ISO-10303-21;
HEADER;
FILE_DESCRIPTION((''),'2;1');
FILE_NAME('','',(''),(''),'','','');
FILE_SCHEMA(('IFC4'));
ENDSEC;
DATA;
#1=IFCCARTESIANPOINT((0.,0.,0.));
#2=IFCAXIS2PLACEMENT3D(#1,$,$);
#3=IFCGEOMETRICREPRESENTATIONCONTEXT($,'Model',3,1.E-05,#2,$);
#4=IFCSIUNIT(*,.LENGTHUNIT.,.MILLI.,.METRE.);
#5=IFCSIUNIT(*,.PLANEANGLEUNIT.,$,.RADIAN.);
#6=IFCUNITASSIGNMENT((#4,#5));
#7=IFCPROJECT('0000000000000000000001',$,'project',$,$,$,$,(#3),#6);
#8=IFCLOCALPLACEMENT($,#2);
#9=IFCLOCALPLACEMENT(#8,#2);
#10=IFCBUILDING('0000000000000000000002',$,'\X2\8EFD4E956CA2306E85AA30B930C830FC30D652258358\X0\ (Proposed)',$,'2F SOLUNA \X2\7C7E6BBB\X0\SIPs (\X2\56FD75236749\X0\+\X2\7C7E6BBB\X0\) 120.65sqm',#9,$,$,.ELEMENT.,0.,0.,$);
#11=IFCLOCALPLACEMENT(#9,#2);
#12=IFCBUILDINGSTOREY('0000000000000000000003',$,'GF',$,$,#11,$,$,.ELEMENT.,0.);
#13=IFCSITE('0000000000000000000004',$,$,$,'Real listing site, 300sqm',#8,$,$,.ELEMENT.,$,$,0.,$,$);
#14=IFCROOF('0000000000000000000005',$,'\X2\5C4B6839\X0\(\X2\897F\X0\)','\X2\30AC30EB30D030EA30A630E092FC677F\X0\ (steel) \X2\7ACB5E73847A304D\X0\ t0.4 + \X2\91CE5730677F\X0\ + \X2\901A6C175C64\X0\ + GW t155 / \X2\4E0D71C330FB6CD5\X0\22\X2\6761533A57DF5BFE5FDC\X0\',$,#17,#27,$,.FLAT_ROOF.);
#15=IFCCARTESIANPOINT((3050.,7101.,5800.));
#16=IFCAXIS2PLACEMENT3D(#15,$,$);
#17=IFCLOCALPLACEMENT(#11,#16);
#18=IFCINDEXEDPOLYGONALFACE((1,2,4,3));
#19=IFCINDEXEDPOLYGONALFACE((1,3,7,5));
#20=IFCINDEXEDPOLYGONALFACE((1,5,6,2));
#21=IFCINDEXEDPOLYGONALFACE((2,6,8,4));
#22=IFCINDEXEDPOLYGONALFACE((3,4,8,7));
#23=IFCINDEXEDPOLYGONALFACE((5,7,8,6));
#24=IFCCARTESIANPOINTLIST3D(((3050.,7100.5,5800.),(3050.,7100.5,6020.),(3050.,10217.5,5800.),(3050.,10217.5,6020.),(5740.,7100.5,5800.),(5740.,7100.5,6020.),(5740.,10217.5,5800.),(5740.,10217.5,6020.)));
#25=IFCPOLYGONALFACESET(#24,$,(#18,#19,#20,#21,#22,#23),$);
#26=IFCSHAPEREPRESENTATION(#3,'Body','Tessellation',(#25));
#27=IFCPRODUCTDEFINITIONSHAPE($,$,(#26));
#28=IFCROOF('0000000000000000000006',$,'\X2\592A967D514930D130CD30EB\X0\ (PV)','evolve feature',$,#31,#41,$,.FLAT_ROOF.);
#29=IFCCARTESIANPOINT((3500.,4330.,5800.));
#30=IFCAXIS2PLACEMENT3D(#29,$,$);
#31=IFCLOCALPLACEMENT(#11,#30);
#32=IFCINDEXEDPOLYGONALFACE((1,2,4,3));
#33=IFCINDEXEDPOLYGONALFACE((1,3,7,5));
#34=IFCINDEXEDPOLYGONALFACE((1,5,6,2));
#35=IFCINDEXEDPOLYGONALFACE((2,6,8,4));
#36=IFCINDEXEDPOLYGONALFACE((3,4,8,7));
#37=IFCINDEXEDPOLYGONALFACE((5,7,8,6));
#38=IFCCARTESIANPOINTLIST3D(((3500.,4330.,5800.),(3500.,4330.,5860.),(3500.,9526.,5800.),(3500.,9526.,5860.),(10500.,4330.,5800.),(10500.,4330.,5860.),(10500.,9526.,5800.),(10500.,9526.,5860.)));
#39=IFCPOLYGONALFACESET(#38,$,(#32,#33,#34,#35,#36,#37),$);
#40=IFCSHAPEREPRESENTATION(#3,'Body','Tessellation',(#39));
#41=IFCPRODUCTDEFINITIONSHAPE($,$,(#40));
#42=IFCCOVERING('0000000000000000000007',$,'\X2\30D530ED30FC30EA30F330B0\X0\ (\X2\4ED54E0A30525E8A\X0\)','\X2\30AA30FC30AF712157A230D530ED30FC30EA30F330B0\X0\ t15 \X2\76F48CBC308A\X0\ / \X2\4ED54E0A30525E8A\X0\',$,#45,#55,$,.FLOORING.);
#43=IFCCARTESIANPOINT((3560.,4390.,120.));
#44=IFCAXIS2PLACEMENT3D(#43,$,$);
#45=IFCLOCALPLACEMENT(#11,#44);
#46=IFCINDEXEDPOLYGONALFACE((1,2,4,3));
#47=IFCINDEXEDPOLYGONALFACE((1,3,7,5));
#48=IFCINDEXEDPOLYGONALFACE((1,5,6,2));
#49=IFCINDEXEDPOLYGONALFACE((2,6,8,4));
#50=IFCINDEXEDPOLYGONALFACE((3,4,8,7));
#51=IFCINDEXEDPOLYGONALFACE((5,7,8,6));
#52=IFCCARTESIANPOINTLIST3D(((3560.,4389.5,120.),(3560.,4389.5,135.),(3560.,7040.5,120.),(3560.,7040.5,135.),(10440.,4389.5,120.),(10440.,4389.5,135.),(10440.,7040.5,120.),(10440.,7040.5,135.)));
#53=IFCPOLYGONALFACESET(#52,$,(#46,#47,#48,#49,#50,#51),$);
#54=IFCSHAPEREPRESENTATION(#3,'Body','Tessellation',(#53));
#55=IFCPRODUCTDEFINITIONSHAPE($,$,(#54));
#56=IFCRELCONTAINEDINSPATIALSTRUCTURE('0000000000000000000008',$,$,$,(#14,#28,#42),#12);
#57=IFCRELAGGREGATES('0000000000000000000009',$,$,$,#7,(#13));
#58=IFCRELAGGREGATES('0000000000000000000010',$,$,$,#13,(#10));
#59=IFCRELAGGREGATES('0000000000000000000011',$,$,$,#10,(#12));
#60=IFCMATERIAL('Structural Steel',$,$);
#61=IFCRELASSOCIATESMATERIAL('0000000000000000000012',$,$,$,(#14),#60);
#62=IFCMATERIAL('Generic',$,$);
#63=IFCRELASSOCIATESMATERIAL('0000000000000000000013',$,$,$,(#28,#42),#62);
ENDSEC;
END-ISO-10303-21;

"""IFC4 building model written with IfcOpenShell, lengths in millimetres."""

from ifc_helpers import new_model, si_unit, frame, frame_2d, origin, place, context, project, spatial, rectangle, extrude, material, element, save


model = new_model("IFC4")

# Units and contexts
model_context = context("Model", 3, precision=1e-05, world=origin())
ifc_project = project(units=[si_unit("LENGTHUNIT", "METRE", prefix="MILLI"), si_unit("PLANEANGLEUNIT", "RADIAN")], contexts=[model_context])

# Site, building, storey
site_placement = place(None, origin())
site = spatial("IfcSite", under=ifc_project, at=site_placement, ObjectType="Real listing site, 300sqm", CompositionType="ELEMENT", RefElevation=0.0)
building_placement = place(site_placement, origin())
building = spatial("IfcBuilding", under=site, at=building_placement, Name="軽井沢の薪ストーブ別荘 (Proposed)", ObjectType="2F SOLUNA 籾殻SIPs (国産杉+籾殻) 120.65sqm", CompositionType="ELEMENT", ElevationOfRefHeight=0.0, ElevationOfTerrain=0.0)
storey_placement = place(building_placement, origin())
storey = spatial("IfcBuildingStorey", under=building, at=storey_placement, Name="GF", CompositionType="ELEMENT", Elevation=0.0)

# Shared definitions
ifc_material_1 = material(Name="Generic")

# Roofs
ifc_material_2 = material(Name="Structural Steel")
roof_1_placement = place(storey_placement, frame((3050.0, 7101.0, 5800.0)))
element("IfcRoof", 1, at=roof_1_placement, inside=storey, material=ifc_material_2, Name="屋根(西)", Description="ガルバリウム鋼板 (steel) 立平葺き t0.4 + 野地板 + 通気層 + GW t155 / 不燃・法22条区域対応", PredefinedType="FLAT_ROOF", context=model_context, shape_type="SweptSolid", body=[
    extrude(rectangle(XDim=2690.0, YDim=3117.0, at=frame_2d((1345.0, 1558.0))), frame((3050.0, 7101.0, 5800.0)), (0.0, 0.0, 1.0), 220.0),
])
roof_2_placement = place(storey_placement, frame((3500.0, 4330.0, 5800.0)))
element("IfcRoof", 2, at=roof_2_placement, inside=storey, material=ifc_material_1, Name="太陽光パネル (PV)", Description="evolve feature", PredefinedType="FLAT_ROOF", context=model_context, shape_type="SweptSolid", body=[
    extrude(rectangle(XDim=7000.0, YDim=5196.0, at=frame_2d((3500.0, 2598.0))), frame((3500.0, 4330.0, 5800.0)), (0.0, 0.0, 1.0), 60.0),
])

# Covering
covering_placement = place(storey_placement, frame((3560.0, 4390.0, 120.0)))
element("IfcCovering", 3, at=covering_placement, inside=storey, material=ifc_material_1, Name="フローリング (仕上げ床)", Description="オーク無垢フローリング t15 直貼り / 仕上げ床", PredefinedType="FLOORING", context=model_context, shape_type="SweptSolid", body=[
    extrude(rectangle(XDim=6880.0, YDim=2651.0, at=frame_2d((3440.0, 1325.0))), frame((3560.0, 4390.0, 120.0)), (0.0, 0.0, 1.0), 15.0),
])

save(model, "model.ifc")
